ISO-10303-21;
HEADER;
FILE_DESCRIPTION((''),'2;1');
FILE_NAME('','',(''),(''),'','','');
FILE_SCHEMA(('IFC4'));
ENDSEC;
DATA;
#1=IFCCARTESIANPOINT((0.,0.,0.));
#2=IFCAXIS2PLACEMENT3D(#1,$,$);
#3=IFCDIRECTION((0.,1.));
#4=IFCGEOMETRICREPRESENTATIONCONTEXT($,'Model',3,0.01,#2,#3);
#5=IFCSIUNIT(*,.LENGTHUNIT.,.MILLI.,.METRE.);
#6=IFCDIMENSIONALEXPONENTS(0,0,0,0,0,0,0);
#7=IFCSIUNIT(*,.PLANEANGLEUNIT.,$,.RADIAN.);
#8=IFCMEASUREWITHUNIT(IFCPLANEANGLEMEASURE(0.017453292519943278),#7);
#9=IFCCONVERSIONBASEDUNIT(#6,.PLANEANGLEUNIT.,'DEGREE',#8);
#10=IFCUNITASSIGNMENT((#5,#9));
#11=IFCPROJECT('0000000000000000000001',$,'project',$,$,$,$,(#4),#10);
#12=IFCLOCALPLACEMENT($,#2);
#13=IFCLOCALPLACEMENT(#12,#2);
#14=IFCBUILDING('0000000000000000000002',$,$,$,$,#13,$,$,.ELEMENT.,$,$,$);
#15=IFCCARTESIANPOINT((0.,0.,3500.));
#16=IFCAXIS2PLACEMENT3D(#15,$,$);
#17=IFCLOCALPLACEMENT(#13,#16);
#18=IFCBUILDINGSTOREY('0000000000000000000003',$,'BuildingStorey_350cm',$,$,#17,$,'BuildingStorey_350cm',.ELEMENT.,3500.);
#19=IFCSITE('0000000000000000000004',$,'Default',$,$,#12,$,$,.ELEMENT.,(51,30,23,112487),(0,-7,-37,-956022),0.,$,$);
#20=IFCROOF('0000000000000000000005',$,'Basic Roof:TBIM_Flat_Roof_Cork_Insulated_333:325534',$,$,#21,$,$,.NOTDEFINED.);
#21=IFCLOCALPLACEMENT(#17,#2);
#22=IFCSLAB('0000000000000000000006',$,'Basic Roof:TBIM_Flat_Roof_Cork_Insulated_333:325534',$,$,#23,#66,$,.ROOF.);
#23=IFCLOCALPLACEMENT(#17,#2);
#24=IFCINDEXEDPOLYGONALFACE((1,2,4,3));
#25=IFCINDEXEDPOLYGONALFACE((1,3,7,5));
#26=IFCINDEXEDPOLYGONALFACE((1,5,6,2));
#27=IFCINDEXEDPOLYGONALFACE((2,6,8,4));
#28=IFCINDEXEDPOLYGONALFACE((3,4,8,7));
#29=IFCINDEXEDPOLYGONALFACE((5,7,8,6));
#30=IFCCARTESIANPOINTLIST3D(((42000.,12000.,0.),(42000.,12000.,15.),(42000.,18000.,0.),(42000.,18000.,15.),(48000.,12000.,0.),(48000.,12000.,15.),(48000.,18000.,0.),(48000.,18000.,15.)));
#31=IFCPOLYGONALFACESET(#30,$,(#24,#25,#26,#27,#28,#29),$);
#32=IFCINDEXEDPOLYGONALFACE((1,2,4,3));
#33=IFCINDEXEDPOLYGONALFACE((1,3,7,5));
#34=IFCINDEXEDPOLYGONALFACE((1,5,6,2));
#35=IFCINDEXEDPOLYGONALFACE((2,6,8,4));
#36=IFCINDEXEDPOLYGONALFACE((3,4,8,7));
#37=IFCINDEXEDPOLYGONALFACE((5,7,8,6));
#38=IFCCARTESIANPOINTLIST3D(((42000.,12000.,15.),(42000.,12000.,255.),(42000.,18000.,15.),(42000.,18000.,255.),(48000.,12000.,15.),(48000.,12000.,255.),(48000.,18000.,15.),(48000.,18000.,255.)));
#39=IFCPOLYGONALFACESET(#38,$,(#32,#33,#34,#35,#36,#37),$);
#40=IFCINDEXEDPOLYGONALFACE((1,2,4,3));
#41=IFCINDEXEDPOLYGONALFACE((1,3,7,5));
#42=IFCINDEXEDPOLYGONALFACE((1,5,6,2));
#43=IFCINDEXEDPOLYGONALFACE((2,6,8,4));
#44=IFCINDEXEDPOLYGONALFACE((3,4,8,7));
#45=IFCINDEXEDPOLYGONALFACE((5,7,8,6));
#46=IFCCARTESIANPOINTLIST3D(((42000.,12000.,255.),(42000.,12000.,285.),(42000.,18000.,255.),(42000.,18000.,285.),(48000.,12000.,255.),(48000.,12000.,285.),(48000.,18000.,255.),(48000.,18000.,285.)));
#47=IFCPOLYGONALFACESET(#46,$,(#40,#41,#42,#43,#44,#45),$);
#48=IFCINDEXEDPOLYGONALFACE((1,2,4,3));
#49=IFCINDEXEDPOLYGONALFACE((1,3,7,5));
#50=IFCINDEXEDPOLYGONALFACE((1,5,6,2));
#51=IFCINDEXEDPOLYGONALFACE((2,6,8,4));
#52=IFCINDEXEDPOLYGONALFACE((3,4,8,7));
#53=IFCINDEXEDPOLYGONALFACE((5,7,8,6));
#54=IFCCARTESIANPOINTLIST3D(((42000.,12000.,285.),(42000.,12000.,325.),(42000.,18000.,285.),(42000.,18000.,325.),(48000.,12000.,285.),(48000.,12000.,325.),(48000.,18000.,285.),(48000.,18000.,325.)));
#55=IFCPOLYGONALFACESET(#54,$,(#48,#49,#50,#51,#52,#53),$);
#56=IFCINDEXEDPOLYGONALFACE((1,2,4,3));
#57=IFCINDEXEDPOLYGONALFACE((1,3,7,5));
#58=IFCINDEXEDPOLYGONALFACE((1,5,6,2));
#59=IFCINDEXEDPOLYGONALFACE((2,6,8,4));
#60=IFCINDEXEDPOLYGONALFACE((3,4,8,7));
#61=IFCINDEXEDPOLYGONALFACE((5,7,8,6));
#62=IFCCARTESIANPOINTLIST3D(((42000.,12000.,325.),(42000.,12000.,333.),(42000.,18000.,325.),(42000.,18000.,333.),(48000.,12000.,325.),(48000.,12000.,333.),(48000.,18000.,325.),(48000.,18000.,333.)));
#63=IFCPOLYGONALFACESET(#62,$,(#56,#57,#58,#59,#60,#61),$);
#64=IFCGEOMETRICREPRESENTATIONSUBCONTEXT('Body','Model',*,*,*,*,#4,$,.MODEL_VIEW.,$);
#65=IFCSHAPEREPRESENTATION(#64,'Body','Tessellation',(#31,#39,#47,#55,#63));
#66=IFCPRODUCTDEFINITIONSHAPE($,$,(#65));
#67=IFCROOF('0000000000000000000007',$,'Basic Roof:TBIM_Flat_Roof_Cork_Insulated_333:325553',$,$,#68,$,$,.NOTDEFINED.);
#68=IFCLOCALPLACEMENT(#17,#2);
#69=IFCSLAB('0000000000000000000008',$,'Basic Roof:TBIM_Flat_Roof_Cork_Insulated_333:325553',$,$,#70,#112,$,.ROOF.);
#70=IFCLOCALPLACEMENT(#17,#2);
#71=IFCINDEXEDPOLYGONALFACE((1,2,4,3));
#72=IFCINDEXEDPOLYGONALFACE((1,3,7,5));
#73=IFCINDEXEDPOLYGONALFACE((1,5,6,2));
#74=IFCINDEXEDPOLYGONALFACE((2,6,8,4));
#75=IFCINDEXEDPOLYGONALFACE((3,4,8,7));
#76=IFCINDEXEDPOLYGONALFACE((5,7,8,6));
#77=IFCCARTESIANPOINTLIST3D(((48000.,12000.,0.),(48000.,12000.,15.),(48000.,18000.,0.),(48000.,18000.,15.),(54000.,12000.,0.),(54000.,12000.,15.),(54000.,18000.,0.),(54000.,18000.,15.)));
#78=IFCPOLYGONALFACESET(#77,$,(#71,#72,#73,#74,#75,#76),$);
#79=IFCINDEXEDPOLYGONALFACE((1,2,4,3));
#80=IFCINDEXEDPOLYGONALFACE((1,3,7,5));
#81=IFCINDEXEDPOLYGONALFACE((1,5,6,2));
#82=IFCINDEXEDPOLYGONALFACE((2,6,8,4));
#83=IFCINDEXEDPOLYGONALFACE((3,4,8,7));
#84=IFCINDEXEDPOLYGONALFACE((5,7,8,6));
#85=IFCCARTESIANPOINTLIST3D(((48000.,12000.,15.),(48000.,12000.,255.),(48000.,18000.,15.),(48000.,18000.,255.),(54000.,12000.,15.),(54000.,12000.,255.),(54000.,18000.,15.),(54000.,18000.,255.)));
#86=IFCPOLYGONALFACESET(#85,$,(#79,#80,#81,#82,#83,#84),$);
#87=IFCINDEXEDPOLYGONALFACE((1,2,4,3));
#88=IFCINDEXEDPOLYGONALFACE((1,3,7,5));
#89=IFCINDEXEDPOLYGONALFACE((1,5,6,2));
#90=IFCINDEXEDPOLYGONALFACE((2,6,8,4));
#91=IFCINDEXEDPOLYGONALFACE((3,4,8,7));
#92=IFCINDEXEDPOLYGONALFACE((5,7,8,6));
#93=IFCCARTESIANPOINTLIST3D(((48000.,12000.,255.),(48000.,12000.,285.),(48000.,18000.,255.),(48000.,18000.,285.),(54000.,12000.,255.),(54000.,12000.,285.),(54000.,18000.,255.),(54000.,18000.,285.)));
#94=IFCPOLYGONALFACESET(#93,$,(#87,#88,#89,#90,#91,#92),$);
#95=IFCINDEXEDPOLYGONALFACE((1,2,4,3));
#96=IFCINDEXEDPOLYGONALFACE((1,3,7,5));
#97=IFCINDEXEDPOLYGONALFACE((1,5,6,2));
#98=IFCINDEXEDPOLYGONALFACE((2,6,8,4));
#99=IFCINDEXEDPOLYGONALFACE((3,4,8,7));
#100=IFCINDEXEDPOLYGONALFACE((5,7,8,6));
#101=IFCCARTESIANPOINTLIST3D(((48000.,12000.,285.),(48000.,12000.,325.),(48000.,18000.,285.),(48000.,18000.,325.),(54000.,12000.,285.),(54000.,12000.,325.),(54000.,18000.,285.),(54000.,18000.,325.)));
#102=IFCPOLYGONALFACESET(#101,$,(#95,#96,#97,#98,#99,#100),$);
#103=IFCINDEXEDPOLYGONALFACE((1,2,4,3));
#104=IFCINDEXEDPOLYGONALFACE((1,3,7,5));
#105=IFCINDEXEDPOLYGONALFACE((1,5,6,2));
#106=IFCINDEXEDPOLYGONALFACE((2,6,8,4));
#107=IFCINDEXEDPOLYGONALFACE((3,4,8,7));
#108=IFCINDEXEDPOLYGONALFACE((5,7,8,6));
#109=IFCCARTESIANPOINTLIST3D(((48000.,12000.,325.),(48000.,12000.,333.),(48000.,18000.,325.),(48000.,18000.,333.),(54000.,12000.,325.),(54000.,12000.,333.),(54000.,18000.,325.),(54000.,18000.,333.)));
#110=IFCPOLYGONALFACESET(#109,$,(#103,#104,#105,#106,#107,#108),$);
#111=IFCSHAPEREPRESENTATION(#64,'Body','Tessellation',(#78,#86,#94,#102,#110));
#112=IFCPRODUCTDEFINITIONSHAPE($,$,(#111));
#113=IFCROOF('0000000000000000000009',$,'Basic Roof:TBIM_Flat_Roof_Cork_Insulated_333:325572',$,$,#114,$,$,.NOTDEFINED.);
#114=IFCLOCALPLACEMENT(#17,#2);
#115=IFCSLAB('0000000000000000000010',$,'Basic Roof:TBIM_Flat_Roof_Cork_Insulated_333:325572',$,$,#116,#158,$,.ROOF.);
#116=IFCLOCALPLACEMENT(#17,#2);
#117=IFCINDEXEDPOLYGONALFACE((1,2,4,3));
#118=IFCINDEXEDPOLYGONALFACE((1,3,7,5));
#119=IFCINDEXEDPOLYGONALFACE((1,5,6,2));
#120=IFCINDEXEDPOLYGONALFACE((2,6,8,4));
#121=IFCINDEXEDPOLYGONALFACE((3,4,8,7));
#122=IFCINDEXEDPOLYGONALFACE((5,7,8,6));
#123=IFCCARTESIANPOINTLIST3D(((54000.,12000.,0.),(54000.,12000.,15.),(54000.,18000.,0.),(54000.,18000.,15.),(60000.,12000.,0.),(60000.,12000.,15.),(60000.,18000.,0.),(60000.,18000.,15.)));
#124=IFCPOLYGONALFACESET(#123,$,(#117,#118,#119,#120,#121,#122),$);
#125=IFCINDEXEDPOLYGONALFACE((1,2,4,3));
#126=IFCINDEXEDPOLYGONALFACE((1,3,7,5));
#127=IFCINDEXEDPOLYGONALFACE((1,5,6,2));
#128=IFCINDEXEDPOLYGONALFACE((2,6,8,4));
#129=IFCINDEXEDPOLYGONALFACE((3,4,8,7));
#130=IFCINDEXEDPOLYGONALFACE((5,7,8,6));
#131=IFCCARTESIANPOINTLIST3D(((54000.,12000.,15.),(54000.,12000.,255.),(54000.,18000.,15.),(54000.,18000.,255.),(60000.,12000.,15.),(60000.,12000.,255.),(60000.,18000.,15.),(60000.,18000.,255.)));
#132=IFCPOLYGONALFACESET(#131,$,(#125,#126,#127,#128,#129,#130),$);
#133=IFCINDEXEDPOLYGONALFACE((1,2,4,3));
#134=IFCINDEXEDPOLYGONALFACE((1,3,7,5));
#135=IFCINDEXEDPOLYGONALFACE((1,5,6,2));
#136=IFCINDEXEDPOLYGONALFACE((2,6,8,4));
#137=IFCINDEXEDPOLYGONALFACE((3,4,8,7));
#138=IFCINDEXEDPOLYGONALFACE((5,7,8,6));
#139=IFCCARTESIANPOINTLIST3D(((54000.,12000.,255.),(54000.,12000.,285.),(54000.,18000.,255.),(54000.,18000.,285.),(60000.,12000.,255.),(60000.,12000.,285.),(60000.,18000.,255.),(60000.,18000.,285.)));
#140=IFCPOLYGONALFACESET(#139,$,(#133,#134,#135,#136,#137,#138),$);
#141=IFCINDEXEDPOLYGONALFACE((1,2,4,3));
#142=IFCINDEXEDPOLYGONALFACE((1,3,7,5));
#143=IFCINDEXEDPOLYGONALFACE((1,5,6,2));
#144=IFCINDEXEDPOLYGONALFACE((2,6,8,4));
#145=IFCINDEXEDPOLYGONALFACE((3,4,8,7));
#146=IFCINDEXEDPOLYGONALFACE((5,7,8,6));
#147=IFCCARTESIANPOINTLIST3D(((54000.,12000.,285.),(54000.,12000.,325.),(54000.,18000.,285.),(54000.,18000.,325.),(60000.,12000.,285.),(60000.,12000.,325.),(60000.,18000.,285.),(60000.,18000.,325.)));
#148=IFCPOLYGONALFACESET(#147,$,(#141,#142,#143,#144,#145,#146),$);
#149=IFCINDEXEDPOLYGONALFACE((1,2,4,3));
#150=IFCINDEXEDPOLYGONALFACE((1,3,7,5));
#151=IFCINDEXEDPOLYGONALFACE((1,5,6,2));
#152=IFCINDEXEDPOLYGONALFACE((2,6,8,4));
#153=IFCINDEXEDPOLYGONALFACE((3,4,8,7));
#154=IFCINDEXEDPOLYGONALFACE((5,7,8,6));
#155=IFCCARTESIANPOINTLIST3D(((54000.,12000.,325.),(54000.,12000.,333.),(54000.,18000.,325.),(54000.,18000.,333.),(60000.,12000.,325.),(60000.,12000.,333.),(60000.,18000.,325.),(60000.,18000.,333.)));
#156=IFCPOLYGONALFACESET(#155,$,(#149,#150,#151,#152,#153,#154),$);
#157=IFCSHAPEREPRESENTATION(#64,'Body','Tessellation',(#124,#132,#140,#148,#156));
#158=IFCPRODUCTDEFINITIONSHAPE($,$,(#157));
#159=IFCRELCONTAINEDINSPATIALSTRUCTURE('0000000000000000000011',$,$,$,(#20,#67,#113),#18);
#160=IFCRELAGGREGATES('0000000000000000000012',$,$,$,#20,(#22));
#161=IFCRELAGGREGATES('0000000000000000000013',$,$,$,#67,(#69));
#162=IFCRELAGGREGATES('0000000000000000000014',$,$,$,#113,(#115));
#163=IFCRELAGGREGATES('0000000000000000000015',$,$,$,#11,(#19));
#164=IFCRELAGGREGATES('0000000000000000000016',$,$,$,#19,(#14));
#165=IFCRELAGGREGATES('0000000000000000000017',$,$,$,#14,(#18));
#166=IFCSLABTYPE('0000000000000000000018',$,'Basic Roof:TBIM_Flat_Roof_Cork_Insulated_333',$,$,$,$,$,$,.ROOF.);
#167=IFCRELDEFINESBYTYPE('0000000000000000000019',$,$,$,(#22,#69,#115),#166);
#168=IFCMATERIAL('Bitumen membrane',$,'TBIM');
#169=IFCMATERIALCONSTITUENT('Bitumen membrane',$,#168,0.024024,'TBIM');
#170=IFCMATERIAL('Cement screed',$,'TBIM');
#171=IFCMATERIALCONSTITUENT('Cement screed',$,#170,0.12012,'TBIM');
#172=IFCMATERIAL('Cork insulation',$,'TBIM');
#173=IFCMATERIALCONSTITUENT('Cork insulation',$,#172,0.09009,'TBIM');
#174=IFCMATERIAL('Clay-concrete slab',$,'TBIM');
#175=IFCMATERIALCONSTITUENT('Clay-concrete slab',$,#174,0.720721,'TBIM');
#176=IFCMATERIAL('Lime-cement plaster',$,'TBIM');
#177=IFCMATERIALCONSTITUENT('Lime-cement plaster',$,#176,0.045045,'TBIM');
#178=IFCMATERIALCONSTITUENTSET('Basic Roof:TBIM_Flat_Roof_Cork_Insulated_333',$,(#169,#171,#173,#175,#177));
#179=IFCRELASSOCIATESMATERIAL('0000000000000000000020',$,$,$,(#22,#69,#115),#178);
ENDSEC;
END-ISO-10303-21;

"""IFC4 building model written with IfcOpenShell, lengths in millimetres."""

from ifc_helpers import new_model, entity, si_unit, converted_unit, direction, frame, origin, place, context, subcontext, project, spatial, indexed_curve, outline, extrude, material, constituent, constituent_set, type_object, element, aggregate, save


model = new_model("IFC4")

# Units and contexts
model_context = context("Model", 3, precision=0.01, world=origin(), true_north=direction((0.0, 1.0)))
body_context = subcontext(model_context, "Body", "Model", "MODEL_VIEW")
ifc_project = project(units=[si_unit("LENGTHUNIT", "METRE", prefix="MILLI"), converted_unit("PLANEANGLEUNIT", "DEGREE", entity("IfcPlaneAngleMeasure", 0.017453292519943278), si_unit("PLANEANGLEUNIT", "RADIAN"), dimensions=[0, 0, 0, 0, 0, 0, 0])], contexts=[model_context])

# Site, building, storey
site_placement = place(None, origin())
site = spatial("IfcSite", under=ifc_project, at=site_placement, Name="Default", CompositionType="ELEMENT", RefLatitude=(51, 30, 23, 112487), RefLongitude=(0, -7, -37, -956022), RefElevation=0.0)
building_placement = place(site_placement, origin())
building = spatial("IfcBuilding", under=site, at=building_placement, CompositionType="ELEMENT")
storey_placement = place(building_placement, frame((0.0, 0.0, 3500.0)))
storey = spatial("IfcBuildingStorey", under=building, at=storey_placement, Name="BuildingStorey_350cm", LongName="BuildingStorey_350cm", CompositionType="ELEMENT", Elevation=3500.0)

# Roofs, slabs
roof_1_placement = place(storey_placement, frame((42000.0, 12000.0, 0.0)))
roof_1 = element("IfcRoof", 1, at=roof_1_placement, inside=storey, Name="Basic Roof:TBIM_Flat_Roof_Cork_Insulated_333:325534", PredefinedType="NOTDEFINED")
ifc_material_1 = material(Name="Bitumen membrane", Category="TBIM")
ifc_constituent_1 = constituent(ifc_material_1, Name="Bitumen membrane", Category="TBIM", fraction=0.024024)
ifc_material_2 = material(Name="Cement screed", Category="TBIM")
ifc_constituent_2 = constituent(ifc_material_2, Name="Cement screed", Category="TBIM", fraction=0.12012)
ifc_material_3 = material(Name="Cork insulation", Category="TBIM")
ifc_constituent_3 = constituent(ifc_material_3, Name="Cork insulation", Category="TBIM", fraction=0.09009)
ifc_material_4 = material(Name="Clay-concrete slab", Category="TBIM")
ifc_constituent_4 = constituent(ifc_material_4, Name="Clay-concrete slab", Category="TBIM", fraction=0.720721)
ifc_material_5 = material(Name="Lime-cement plaster", Category="TBIM")
ifc_constituent_5 = constituent(ifc_material_5, Name="Lime-cement plaster", Category="TBIM", fraction=0.045045)
ifc_constituent_set_1 = constituent_set(constituents=[ifc_constituent_1, ifc_constituent_2, ifc_constituent_3, ifc_constituent_4, ifc_constituent_5], Name="Basic Roof:TBIM_Flat_Roof_Cork_Insulated_333")
slab_type = type_object("IfcSlabType", Name="Basic Roof:TBIM_Flat_Roof_Cork_Insulated_333", PredefinedType="ROOF")
slab_1_placement = place(roof_1_placement, origin())
slab_1 = element("IfcSlab", 2, at=slab_1_placement, type_object=slab_type, material=ifc_constituent_set_1, Name="Basic Roof:TBIM_Flat_Roof_Cork_Insulated_333:325534", PredefinedType="ROOF", context=body_context, shape_type="SweptSolid", body=[
    extrude(outline(indexed_curve([(-3000.0, 3000.0), (-3000.0, -3000.0), (3000.0, -3000.0), (3000.0, 3000.0), (-3000.0, 3000.0)], self_intersect=False)), frame((3000.0, 3000.0, 0.0)), (0.0, 0.0, 1.0), 15.0),
    extrude(outline(indexed_curve([(-3000.0, 3000.0), (-3000.0, -3000.0), (3000.0, -3000.0), (3000.0, 3000.0), (-3000.0, 3000.0)], self_intersect=False)), frame((3000.0, 3000.0, 15.0)), (0.0, 0.0, 1.0), 240.0),
    extrude(outline(indexed_curve([(-3000.0, 3000.0), (-3000.0, -3000.0), (3000.0, -3000.0), (3000.0, 3000.0), (-3000.0, 3000.0)], self_intersect=False)), frame((3000.0, 3000.0, 255.0)), (0.0, 0.0, 1.0), 30.0),
    extrude(outline(indexed_curve([(-3000.0, 3000.0), (-3000.0, -3000.0), (3000.0, -3000.0), (3000.0, 3000.0), (-3000.0, 3000.0)], self_intersect=False)), frame((3000.0, 3000.0, 285.0)), (0.0, 0.0, 1.0), 40.0),
    extrude(outline(indexed_curve([(-3000.0, 3000.0), (-3000.0, -3000.0), (3000.0, -3000.0), (3000.0, 3000.0), (-3000.0, 3000.0)], self_intersect=False)), frame((3000.0, 3000.0, 325.0)), (0.0, 0.0, 1.0), 8.0),
])
aggregate(roof_1, [slab_1])
roof_2_placement = place(storey_placement, frame((48000.0, 12000.0, 0.0)))
roof_2 = element("IfcRoof", 3, at=roof_2_placement, inside=storey, Name="Basic Roof:TBIM_Flat_Roof_Cork_Insulated_333:325553", PredefinedType="NOTDEFINED")
slab_2_placement = place(roof_2_placement, origin())
slab_2 = element("IfcSlab", 4, at=slab_2_placement, type_object=slab_type, material=ifc_constituent_set_1, Name="Basic Roof:TBIM_Flat_Roof_Cork_Insulated_333:325553", PredefinedType="ROOF", context=body_context, shape_type="SweptSolid", body=[
    extrude(outline(indexed_curve([(-3000.0, 3000.0), (-3000.0, -3000.0), (3000.0, -3000.0), (3000.0, 3000.0), (-3000.0, 3000.0)], self_intersect=False)), frame((3000.0, 3000.0, 0.0)), (0.0, 0.0, 1.0), 15.0),
    extrude(outline(indexed_curve([(-3000.0, 3000.0), (-3000.0, -3000.0), (3000.0, -3000.0), (3000.0, 3000.0), (-3000.0, 3000.0)], self_intersect=False)), frame((3000.0, 3000.0, 15.0)), (0.0, 0.0, 1.0), 240.0),
    extrude(outline(indexed_curve([(-3000.0, 3000.0), (-3000.0, -3000.0), (3000.0, -3000.0), (3000.0, 3000.0), (-3000.0, 3000.0)], self_intersect=False)), frame((3000.0, 3000.0, 255.0)), (0.0, 0.0, 1.0), 30.0),
    extrude(outline(indexed_curve([(-3000.0, 3000.0), (-3000.0, -3000.0), (3000.0, -3000.0), (3000.0, 3000.0), (-3000.0, 3000.0)], self_intersect=False)), frame((3000.0, 3000.0, 285.0)), (0.0, 0.0, 1.0), 40.0),
    extrude(outline(indexed_curve([(-3000.0, 3000.0), (-3000.0, -3000.0), (3000.0, -3000.0), (3000.0, 3000.0), (-3000.0, 3000.0)], self_intersect=False)), frame((3000.0, 3000.0, 325.0)), (0.0, 0.0, 1.0), 8.0),
])
aggregate(roof_2, [slab_2])
roof_3_placement = place(storey_placement, frame((54000.0, 12000.0, 0.0)))
roof_3 = element("IfcRoof", 5, at=roof_3_placement, inside=storey, Name="Basic Roof:TBIM_Flat_Roof_Cork_Insulated_333:325572", PredefinedType="NOTDEFINED")
slab_3_placement = place(roof_3_placement, origin())
slab_3 = element("IfcSlab", 6, at=slab_3_placement, type_object=slab_type, material=ifc_constituent_set_1, Name="Basic Roof:TBIM_Flat_Roof_Cork_Insulated_333:325572", PredefinedType="ROOF", context=body_context, shape_type="SweptSolid", body=[
    extrude(outline(indexed_curve([(-3000.0, 3000.0), (-3000.0, -3000.0), (3000.0, -3000.0), (3000.0, 3000.0), (-3000.0, 3000.0)], self_intersect=False)), frame((3000.0, 3000.0, 0.0)), (0.0, 0.0, 1.0), 15.0),
    extrude(outline(indexed_curve([(-3000.0, 3000.0), (-3000.0, -3000.0), (3000.0, -3000.0), (3000.0, 3000.0), (-3000.0, 3000.0)], self_intersect=False)), frame((3000.0, 3000.0, 15.0)), (0.0, 0.0, 1.0), 240.0),
    extrude(outline(indexed_curve([(-3000.0, 3000.0), (-3000.0, -3000.0), (3000.0, -3000.0), (3000.0, 3000.0), (-3000.0, 3000.0)], self_intersect=False)), frame((3000.0, 3000.0, 255.0)), (0.0, 0.0, 1.0), 30.0),
    extrude(outline(indexed_curve([(-3000.0, 3000.0), (-3000.0, -3000.0), (3000.0, -3000.0), (3000.0, 3000.0), (-3000.0, 3000.0)], self_intersect=False)), frame((3000.0, 3000.0, 285.0)), (0.0, 0.0, 1.0), 40.0),
    extrude(outline(indexed_curve([(-3000.0, 3000.0), (-3000.0, -3000.0), (3000.0, -3000.0), (3000.0, 3000.0), (-3000.0, 3000.0)], self_intersect=False)), frame((3000.0, 3000.0, 325.0)), (0.0, 0.0, 1.0), 8.0),
])
aggregate(roof_3, [slab_3])

save(model, "model.ifc")
